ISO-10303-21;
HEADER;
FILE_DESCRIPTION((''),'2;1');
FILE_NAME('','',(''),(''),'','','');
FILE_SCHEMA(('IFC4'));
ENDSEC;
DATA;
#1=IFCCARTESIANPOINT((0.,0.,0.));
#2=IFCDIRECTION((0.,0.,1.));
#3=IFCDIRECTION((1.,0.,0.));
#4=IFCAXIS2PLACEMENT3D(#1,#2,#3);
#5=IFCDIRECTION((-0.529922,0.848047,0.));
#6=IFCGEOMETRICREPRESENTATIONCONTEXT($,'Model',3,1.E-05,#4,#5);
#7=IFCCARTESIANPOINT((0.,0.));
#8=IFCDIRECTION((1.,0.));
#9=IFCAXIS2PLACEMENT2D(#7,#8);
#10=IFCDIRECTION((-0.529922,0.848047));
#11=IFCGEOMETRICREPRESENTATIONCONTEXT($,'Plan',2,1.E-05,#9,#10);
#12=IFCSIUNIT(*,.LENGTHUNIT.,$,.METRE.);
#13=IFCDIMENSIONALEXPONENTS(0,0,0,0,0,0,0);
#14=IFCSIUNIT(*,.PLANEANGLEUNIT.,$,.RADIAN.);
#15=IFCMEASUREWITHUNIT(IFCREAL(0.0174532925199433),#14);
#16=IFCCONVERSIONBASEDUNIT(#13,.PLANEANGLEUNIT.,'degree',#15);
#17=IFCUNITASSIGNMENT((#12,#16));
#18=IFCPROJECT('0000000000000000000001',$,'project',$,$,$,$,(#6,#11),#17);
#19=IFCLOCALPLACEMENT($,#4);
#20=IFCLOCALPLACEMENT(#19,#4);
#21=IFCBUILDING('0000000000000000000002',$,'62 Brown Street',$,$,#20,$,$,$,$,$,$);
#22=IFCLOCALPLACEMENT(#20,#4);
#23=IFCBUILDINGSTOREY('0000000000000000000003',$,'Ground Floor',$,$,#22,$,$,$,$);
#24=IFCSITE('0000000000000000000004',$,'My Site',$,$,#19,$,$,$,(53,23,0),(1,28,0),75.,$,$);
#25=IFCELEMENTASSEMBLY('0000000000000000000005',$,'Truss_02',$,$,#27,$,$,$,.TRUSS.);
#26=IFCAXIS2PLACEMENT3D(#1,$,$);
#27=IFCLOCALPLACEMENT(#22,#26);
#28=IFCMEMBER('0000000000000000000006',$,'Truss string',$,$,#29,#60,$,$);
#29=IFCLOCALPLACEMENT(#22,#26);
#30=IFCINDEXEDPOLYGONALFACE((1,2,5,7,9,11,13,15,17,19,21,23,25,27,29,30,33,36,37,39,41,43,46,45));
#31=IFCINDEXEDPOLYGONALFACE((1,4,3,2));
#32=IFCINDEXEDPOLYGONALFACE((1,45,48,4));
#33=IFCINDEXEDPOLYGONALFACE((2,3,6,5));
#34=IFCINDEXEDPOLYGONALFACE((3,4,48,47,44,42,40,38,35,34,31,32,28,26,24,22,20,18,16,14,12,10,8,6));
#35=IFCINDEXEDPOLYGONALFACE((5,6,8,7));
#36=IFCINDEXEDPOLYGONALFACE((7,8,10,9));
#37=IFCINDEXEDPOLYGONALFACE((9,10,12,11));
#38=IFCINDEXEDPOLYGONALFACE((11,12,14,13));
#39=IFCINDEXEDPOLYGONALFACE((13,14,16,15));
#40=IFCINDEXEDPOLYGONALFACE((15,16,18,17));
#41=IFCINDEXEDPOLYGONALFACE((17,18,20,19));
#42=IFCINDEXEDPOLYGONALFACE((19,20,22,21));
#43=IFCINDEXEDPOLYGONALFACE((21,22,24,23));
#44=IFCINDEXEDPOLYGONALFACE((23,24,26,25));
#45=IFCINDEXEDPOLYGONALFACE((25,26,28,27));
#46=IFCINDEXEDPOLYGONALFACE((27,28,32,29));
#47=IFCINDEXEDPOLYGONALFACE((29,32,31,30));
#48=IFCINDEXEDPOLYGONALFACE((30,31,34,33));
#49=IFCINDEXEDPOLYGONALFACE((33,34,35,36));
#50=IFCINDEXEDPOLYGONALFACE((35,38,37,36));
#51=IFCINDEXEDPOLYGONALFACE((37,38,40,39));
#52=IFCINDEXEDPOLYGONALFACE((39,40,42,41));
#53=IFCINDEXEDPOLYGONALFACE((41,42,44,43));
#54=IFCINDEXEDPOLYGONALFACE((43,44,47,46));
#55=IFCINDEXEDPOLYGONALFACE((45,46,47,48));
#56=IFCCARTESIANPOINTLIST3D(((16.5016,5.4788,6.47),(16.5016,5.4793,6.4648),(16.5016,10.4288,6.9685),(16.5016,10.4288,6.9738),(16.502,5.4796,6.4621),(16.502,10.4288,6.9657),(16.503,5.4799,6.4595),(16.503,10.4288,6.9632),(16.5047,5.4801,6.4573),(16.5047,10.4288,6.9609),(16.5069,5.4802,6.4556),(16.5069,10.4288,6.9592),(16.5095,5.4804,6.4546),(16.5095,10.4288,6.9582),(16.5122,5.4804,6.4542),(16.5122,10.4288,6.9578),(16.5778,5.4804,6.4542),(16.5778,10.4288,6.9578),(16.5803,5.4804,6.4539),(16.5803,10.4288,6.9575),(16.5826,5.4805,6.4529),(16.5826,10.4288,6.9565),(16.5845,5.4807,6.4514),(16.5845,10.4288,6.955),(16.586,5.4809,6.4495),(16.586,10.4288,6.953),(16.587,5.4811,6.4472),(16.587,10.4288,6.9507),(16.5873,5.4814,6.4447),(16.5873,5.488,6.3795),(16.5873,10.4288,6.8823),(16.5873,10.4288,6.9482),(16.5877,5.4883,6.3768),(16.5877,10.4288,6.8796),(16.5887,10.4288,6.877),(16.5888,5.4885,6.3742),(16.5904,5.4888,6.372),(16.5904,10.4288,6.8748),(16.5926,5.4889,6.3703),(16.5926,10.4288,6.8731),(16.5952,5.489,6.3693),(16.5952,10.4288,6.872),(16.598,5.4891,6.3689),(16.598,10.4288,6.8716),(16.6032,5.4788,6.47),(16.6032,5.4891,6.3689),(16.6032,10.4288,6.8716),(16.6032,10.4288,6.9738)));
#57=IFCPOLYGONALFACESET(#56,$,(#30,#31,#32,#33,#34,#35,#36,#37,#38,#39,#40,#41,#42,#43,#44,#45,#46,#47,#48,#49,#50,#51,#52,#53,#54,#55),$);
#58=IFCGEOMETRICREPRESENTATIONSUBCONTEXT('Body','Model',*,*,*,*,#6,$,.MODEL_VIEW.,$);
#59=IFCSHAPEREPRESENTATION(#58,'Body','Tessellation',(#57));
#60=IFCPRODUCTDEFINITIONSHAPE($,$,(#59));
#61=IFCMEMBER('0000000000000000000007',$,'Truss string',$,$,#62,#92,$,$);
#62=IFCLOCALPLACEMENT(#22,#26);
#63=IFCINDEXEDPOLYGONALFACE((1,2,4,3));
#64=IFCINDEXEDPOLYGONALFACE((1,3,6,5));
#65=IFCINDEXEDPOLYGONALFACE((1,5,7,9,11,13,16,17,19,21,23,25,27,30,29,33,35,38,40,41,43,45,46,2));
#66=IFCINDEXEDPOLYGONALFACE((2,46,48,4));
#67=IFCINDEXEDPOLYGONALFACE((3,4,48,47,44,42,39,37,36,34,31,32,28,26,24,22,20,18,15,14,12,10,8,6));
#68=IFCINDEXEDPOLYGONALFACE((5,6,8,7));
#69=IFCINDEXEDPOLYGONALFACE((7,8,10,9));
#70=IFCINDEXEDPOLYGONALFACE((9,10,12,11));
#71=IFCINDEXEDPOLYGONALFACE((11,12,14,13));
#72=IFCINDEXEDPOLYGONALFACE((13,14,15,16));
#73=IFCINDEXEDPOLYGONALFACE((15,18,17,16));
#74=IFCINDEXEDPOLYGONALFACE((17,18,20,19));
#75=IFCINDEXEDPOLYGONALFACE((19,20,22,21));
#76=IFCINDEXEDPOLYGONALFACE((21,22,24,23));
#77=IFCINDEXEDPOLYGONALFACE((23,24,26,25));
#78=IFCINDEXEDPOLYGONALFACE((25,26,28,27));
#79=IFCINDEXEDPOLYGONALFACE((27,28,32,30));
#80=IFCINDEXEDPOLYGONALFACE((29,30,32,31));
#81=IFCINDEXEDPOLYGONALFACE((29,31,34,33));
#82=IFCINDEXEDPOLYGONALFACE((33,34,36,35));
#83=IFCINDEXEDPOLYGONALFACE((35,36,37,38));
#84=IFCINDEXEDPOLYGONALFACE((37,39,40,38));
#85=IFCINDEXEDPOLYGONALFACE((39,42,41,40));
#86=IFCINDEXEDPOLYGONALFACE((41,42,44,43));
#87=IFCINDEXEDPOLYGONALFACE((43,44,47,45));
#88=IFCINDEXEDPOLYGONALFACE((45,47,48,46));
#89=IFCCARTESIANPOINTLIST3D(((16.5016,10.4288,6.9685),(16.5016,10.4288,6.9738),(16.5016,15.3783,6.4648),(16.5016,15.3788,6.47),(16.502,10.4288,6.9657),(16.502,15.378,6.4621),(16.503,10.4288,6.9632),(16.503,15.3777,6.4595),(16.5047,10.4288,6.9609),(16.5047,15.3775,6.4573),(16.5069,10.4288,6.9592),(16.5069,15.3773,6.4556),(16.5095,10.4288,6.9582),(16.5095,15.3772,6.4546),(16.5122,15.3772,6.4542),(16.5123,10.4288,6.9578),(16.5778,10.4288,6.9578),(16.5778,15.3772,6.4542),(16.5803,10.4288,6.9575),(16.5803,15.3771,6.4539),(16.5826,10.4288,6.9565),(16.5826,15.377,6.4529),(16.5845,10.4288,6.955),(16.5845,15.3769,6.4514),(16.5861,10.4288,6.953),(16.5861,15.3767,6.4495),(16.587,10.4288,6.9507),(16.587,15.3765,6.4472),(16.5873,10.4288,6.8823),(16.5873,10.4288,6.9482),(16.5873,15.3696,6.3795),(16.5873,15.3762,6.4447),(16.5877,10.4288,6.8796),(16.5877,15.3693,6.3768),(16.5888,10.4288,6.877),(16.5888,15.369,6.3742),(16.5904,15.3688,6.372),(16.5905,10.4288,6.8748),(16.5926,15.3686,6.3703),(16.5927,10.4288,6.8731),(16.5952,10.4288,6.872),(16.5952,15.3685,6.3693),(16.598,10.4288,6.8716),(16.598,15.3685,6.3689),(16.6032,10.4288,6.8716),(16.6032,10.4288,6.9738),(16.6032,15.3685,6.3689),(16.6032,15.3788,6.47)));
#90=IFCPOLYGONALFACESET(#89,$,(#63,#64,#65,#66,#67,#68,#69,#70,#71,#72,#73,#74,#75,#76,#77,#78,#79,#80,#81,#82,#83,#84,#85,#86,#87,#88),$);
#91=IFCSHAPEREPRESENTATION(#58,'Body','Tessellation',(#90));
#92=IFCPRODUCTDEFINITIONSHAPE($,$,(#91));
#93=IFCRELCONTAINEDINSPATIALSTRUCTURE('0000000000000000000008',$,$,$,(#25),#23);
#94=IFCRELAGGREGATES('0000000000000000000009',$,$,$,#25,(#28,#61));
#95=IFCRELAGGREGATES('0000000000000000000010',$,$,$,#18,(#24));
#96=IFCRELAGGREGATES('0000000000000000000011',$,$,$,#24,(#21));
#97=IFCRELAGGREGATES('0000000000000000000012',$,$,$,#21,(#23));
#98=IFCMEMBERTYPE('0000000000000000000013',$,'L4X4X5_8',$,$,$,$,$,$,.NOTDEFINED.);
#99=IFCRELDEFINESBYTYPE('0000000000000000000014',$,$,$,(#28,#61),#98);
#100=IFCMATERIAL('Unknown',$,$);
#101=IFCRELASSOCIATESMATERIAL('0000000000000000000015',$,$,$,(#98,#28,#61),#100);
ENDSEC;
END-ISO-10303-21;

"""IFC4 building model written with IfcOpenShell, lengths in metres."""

from ifc_helpers import new_model, entity, si_unit, converted_unit, direction, frame, origin_with_axes, origin_2d_with_axis, place, context, subcontext, project, spatial, l_section, extrude, clip, halfspace, material, material_profile, profile_set, profile_usage, type_object, element, aggregate, save


model = new_model("IFC4")

# Units and contexts
model_context = context("Model", 3, precision=1e-05, world=origin_with_axes(), true_north=direction((-0.529922, 0.848047, 0.0)))
plan_context = context("Plan", 2, precision=1e-05, world=origin_2d_with_axis(), true_north=direction((-0.529922, 0.848047)))
body_context = subcontext(model_context, "Body", "Model", "MODEL_VIEW")
ifc_project = project(units=[si_unit("LENGTHUNIT", "METRE"), converted_unit("PLANEANGLEUNIT", "degree", entity("IfcReal", 0.0174532925199433), si_unit("PLANEANGLEUNIT", "RADIAN"), dimensions=[0, 0, 0, 0, 0, 0, 0])], contexts=[model_context, plan_context])

# Site, building, storey
site_placement = place(None, origin_with_axes())
site = spatial("IfcSite", under=ifc_project, at=site_placement, Name="My Site", RefLatitude=(53, 23, 0), RefLongitude=(1, 28, 0), RefElevation=75.0)
building_placement = place(site_placement, origin_with_axes())
building = spatial("IfcBuilding", under=site, at=building_placement, Name="62 Brown Street")
storey_placement = place(building_placement, origin_with_axes())
storey = spatial("IfcBuildingStorey", under=building, at=storey_placement, Name="Ground Floor")

# Element assembly
ifc_material_1 = material(Name="Unknown")
assembly_1_placement = place(storey_placement, frame((16.6032, 10.4288, 6.9738), z_axis=(0.0, 0.0, 1.0), x_axis=(1.0, 0.0, 0.0)))
assembly_1 = element("IfcElementAssembly", 1, at=assembly_1_placement, inside=storey, Name="Truss_02", PredefinedType="TRUSS")

# Members
ifc_material_profile_1 = material_profile(ifc_material_1, l_section(Depth=0.1016, Width=0.1016, Thickness=0.0159, FilletRadius=0.0095, EdgeRadius=0.0106))
ifc_profile_set_1 = profile_set([ifc_material_profile_1])
member_type_1 = type_object("IfcMemberType", Name="L4X4X5_8", PredefinedType="NOTDEFINED", material=ifc_profile_set_1)
ifc_profile_usage_1 = profile_usage(ifc_profile_set_1, cardinal=5)
member_1_placement = place(assembly_1_placement, frame((-0.0508, 0.3519, -0.0152), z_axis=(0.000001, -0.994861, -0.101247), x_axis=(-1.0, -0.000001, 0.0)))
member_1 = element("IfcMember", 2, at=member_1_placement, type_object=member_type_1, material=ifc_profile_usage_1, Name="Truss string", context=body_context, shape_type="Clipping", body=[
    clip(extrude(l_section(Depth=0.1016, Width=0.1016, Thickness=0.0159, FilletRadius=0.0095, EdgeRadius=0.0106), origin_with_axes(), (0.0, 0.0, 1.0), 5.3242), halfspace(frame((16.4524, -0.0508, 0.3486), z_axis=(0.0, 0.101247, -0.994861), x_axis=(1.0, -0.000001, 0.0)), False)),
])
ifc_profile_usage_2 = profile_usage(ifc_profile_set_1, cardinal=5)
member_2_placement = place(assembly_1_placement, frame((-0.0508, 4.9449, -0.5543), z_axis=(0.000001, -0.994861, 0.101247), x_axis=(-1.0, -0.000001, 0.0)))
member_2 = element("IfcMember", 3, at=member_2_placement, type_object=member_type_1, material=ifc_profile_usage_2, Name="Truss string", context=body_context, shape_type="Clipping", body=[
    clip(extrude(l_section(Depth=0.1016, Width=0.1016, Thickness=0.0159, FilletRadius=0.0095, EdgeRadius=0.0106), origin_with_axes(), (0.0, 0.0, 1.0), 5.3242), halfspace(frame((16.4524, -0.0508, 4.9756), z_axis=(0.0, 0.101247, 0.994861), x_axis=(1.0, -0.000001, 0.0)), False)),
])
aggregate(assembly_1, [member_1, member_2])

save(model, "model.ifc")
